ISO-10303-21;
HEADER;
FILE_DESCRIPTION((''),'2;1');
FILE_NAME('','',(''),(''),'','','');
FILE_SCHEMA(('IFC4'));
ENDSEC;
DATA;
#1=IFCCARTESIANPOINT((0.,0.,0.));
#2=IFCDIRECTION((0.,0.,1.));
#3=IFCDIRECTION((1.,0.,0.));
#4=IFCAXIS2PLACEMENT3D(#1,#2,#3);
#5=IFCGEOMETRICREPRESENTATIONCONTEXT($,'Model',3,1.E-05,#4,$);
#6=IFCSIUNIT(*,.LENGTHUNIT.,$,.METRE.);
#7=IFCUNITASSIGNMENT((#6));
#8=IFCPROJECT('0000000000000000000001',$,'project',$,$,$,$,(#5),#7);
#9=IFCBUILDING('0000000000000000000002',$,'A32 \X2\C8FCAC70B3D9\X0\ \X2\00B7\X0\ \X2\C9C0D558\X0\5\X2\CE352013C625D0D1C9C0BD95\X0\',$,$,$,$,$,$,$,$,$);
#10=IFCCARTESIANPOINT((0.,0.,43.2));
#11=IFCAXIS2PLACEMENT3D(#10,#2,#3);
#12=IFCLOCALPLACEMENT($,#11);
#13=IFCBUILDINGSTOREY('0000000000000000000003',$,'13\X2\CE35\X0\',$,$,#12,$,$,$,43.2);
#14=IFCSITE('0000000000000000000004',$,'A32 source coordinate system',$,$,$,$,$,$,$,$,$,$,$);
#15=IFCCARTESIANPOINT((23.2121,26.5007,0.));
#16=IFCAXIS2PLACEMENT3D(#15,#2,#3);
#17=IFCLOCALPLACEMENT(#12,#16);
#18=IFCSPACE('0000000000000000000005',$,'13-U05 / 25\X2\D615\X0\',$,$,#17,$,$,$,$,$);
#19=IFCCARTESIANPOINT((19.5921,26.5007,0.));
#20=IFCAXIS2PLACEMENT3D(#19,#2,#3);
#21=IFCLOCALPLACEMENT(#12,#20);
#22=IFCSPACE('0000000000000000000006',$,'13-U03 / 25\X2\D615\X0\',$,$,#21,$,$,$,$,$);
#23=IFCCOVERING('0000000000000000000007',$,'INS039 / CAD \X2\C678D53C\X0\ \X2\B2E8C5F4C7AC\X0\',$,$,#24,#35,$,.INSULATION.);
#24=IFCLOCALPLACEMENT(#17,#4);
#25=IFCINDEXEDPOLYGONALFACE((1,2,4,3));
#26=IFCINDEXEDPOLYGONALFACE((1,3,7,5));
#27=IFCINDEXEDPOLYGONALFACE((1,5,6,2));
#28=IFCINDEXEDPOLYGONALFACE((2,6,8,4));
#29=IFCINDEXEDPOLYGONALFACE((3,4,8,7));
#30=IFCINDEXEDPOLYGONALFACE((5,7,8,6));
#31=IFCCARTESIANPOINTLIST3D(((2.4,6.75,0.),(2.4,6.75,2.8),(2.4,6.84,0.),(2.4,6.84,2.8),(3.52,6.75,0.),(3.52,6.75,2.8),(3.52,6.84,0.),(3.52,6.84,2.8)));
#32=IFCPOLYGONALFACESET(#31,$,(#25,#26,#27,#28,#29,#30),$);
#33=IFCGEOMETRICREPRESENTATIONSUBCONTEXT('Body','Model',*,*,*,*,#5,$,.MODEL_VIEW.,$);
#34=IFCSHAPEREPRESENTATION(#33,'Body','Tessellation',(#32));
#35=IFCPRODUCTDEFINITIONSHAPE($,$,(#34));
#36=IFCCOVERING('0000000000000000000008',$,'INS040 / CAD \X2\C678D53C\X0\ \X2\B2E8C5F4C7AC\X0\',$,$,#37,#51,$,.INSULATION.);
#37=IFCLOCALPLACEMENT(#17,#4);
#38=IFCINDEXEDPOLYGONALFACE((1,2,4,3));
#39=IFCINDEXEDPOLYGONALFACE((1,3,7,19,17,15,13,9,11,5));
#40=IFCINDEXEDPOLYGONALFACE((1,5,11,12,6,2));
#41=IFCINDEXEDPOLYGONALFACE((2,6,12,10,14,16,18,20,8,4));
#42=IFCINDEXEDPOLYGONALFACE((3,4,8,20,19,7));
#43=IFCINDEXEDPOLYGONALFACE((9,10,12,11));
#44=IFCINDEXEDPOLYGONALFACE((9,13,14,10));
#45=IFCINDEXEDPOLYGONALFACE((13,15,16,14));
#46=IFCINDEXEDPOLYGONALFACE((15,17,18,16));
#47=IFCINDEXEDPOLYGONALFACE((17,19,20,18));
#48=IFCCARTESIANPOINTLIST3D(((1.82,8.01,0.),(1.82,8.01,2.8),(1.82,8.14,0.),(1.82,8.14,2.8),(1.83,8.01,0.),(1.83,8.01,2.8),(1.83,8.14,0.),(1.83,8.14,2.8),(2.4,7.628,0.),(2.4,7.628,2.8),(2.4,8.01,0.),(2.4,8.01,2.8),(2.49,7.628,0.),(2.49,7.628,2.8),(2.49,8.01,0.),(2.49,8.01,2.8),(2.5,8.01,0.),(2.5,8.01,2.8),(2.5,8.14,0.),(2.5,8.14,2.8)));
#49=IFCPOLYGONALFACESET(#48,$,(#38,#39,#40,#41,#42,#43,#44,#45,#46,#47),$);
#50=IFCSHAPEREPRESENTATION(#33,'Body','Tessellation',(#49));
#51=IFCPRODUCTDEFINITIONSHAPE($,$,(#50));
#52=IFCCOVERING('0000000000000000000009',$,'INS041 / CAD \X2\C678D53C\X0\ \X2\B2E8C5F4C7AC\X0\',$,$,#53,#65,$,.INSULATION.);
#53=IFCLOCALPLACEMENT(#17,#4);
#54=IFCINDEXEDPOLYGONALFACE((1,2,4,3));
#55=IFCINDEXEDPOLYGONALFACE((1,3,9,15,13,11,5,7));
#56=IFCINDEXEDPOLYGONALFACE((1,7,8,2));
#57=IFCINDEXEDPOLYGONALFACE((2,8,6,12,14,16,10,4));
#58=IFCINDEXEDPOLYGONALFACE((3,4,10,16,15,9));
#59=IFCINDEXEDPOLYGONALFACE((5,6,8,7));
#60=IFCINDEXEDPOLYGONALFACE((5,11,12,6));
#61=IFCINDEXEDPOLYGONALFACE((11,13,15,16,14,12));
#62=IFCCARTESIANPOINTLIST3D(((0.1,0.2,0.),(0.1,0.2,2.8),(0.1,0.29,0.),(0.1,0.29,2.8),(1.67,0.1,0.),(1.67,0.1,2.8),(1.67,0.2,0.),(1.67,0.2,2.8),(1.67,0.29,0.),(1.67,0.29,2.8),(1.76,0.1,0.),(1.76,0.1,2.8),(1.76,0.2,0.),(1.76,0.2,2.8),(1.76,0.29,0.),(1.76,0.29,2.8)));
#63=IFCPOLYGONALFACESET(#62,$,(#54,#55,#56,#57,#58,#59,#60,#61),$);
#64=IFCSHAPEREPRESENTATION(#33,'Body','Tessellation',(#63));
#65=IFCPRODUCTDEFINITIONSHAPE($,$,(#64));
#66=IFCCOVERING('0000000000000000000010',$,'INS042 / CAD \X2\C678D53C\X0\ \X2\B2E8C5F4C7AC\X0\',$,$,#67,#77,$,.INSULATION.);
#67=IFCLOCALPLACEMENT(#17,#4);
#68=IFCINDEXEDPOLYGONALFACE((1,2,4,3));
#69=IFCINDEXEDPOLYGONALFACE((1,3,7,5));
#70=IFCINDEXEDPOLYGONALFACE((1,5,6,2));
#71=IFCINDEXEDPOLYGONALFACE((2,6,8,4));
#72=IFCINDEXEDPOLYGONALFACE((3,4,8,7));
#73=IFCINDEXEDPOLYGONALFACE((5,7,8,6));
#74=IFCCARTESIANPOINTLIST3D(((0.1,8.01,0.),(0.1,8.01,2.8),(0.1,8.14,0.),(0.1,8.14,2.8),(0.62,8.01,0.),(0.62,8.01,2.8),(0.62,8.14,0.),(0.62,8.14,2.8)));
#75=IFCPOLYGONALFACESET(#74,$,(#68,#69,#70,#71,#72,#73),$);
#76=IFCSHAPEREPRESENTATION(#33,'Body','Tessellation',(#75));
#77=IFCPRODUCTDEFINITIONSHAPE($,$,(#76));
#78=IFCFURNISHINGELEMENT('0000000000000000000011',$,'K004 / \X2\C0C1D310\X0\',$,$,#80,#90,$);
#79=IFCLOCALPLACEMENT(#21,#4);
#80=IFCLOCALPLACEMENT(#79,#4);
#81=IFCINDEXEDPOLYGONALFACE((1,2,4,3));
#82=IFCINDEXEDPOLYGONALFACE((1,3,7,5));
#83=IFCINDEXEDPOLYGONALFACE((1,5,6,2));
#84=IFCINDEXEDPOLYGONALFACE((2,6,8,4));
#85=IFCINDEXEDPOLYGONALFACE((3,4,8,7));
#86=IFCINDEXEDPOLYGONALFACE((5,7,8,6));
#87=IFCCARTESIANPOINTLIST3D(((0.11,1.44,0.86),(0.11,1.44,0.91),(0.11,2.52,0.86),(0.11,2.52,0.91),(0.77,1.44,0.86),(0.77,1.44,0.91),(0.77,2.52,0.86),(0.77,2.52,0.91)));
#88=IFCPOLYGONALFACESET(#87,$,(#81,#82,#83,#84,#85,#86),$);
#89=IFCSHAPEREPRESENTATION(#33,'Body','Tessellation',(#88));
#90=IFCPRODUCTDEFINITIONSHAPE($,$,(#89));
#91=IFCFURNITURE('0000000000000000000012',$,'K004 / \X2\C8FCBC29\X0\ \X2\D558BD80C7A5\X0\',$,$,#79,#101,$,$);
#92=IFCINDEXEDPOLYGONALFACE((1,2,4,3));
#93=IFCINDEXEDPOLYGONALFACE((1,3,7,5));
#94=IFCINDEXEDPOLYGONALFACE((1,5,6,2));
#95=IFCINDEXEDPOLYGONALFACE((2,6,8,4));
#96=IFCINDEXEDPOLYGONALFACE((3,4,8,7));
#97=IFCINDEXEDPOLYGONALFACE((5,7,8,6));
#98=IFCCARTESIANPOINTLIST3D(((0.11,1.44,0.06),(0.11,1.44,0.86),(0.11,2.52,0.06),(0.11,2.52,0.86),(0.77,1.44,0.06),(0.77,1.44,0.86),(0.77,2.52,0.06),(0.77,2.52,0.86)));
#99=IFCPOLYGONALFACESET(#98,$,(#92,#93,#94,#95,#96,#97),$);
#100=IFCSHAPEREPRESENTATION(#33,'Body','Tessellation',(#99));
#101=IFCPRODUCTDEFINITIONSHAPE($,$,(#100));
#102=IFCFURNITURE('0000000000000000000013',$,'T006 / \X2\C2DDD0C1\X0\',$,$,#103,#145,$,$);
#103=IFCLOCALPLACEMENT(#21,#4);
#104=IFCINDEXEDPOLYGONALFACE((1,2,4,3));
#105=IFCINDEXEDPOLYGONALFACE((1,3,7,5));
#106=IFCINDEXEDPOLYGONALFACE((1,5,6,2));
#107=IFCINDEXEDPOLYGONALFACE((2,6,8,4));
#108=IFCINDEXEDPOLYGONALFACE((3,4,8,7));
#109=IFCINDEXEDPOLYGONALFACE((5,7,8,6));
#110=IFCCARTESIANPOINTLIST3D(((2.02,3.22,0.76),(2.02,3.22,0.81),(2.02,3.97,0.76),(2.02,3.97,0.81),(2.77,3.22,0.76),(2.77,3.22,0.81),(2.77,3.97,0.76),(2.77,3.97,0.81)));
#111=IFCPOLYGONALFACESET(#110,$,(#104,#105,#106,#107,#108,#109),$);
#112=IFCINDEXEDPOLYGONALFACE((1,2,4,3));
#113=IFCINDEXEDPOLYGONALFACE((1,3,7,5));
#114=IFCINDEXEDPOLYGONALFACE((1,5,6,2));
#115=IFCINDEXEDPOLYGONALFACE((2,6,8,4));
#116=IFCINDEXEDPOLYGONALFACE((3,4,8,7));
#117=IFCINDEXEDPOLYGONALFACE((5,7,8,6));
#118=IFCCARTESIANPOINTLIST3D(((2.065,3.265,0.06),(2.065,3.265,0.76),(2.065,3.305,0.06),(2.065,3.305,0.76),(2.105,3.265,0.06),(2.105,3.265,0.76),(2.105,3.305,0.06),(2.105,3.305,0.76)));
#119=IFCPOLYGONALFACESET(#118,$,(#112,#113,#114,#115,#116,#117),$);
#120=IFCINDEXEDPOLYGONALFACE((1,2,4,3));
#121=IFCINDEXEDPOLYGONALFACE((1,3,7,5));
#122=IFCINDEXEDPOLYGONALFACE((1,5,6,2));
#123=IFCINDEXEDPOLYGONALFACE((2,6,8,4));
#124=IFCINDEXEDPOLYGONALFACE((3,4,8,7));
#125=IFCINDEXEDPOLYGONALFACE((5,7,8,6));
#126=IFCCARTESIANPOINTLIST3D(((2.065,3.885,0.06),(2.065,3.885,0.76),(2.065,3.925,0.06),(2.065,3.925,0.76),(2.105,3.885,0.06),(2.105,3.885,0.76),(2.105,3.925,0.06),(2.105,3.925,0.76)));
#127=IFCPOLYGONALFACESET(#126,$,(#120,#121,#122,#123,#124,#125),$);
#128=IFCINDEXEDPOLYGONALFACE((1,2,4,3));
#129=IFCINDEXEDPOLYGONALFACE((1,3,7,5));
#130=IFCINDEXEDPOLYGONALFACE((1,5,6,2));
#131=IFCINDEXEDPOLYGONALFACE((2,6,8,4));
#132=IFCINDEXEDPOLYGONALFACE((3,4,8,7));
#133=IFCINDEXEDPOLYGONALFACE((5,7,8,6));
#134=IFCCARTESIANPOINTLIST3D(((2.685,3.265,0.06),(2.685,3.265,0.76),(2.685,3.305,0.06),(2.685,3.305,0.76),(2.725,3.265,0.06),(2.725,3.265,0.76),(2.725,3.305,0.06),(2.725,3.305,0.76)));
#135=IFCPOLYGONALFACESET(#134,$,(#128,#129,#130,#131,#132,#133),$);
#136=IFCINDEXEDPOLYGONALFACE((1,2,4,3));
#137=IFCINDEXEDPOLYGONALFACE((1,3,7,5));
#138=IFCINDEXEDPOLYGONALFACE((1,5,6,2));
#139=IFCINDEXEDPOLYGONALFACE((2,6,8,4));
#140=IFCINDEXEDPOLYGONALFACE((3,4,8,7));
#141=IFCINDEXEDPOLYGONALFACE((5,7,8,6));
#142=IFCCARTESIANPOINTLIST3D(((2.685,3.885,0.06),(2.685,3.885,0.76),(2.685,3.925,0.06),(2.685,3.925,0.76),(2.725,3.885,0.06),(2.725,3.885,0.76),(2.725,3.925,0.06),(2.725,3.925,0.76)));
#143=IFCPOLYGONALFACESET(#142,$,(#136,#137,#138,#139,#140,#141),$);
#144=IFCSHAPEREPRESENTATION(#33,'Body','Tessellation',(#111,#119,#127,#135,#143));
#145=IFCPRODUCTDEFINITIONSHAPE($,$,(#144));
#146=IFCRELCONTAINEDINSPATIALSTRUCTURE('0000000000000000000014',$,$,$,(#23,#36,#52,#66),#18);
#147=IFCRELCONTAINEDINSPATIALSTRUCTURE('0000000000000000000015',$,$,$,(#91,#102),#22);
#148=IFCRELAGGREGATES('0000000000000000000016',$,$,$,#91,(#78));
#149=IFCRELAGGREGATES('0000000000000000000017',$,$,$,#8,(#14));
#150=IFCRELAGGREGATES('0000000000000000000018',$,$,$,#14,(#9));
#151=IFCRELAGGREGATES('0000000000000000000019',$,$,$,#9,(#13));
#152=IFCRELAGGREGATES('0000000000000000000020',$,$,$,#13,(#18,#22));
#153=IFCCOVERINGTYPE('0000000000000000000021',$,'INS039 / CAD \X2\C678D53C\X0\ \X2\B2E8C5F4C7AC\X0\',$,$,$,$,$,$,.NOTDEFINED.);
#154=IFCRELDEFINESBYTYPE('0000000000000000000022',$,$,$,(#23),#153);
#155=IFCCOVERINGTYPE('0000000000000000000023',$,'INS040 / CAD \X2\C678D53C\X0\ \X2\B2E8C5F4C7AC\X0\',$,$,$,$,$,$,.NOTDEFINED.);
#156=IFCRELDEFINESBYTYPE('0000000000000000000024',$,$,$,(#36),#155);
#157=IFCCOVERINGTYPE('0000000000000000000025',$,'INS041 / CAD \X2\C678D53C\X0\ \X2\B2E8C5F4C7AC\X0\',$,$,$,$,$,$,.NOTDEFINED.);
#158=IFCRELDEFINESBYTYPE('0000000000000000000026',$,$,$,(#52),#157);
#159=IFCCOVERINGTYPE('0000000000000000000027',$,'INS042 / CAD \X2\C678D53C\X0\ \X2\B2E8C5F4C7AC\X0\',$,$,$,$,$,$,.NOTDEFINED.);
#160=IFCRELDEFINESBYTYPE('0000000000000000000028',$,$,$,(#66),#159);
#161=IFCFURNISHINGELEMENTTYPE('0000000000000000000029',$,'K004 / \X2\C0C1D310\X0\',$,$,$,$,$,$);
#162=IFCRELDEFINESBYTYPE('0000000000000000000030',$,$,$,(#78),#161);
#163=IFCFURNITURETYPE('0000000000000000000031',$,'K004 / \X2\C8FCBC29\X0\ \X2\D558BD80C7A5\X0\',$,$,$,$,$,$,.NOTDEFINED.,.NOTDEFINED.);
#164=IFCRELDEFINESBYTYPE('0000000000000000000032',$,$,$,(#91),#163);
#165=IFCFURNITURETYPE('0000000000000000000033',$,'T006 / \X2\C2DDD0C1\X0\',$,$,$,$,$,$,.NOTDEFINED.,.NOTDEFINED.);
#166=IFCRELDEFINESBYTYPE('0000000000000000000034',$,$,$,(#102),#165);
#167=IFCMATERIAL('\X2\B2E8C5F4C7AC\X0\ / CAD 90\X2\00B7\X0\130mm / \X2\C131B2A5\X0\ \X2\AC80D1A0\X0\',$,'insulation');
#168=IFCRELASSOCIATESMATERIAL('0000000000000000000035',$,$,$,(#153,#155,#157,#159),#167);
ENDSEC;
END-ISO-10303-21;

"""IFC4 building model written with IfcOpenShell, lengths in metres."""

from ifc_helpers import new_model, si_unit, frame, origin, origin_with_axes, place, context, subcontext, project, spatial, polyline, outline, extrude, source, transform, mapped, material, type_object, type_shapes, element, aggregate, save


model = new_model("IFC4")

# Units and contexts
model_context = context("Model", 3, precision=1e-05, world=origin_with_axes())
body_context = subcontext(model_context, "Body", "Model", "MODEL_VIEW")
ifc_project = project(units=[si_unit("LENGTHUNIT", "METRE")], contexts=[model_context])

# Site, building, storey, space
storey_placement = place(None, frame((0.0, 0.0, 43.2), z_axis=(0.0, 0.0, 1.0), x_axis=(1.0, 0.0, 0.0)))
space_1_placement = place(storey_placement, frame((23.2121, 26.5007, 0.0), z_axis=(0.0, 0.0, 1.0), x_axis=(1.0, 0.0, 0.0)))
site = spatial("IfcSite", under=ifc_project, Name="A32 source coordinate system")
building = spatial("IfcBuilding", under=site, Name="A32 주거동 · 지하5층–옥탑지붕")
storey = spatial("IfcBuildingStorey", under=building, at=storey_placement, Name="13층", Elevation=43.2)
space_1 = spatial("IfcSpace", under=storey, at=space_1_placement, Name="13-U05 / 25형")

# Shared definitions
space_2_placement = place(storey_placement, frame((19.5921, 26.5007, 0.0), z_axis=(0.0, 0.0, 1.0), x_axis=(1.0, 0.0, 0.0)))
space_2 = spatial("IfcSpace", under=storey, at=space_2_placement, Name="13-U03 / 25형")

# Coverings
ifc_material = material(Name="단열재 / CAD 90·130mm / 성능 검토", Category="insulation")
covering_type_1 = type_object("IfcCoveringType", Name="INS039 / CAD 외피 단열재", PredefinedType="NOTDEFINED", material=ifc_material)
shared_shape_1 = source(origin(), body_context, "Body", "SweptSolid", [
    extrude(outline(polyline([(2.4, 6.75), (2.4, 6.84), (3.52, 6.84), (3.52, 6.75), (2.4, 6.75)])), origin(), (0.0, 0.0, 1.0), 2.8),
])
type_shapes(covering_type_1, [shared_shape_1])
covering_1_placement = place(space_1_placement, origin_with_axes())
element("IfcCovering", 1, at=covering_1_placement, inside=space_1, type_object=covering_type_1, Name="INS039 / CAD 외피 단열재", PredefinedType="INSULATION", context=body_context, shape_type="MappedRepresentation", body=[
    mapped(shared_shape_1, transform((0.0, 0.0, 0.0), scale=1.0)),
])
covering_type_2 = type_object("IfcCoveringType", Name="INS040 / CAD 외피 단열재", PredefinedType="NOTDEFINED", material=ifc_material)
shared_shape_2 = source(origin(), body_context, "Body", "SweptSolid", [
    extrude(outline(polyline([(2.4, 7.628), (2.4, 8.01), (1.83, 8.01), (1.82, 8.01), (1.82, 8.14), (1.83, 8.14), (2.5, 8.14), (2.5, 8.01), (2.49, 8.01), (2.49, 7.628), (2.4, 7.628)])), origin(), (0.0, 0.0, 1.0), 2.8),
])
type_shapes(covering_type_2, [shared_shape_2])
covering_2_placement = place(space_1_placement, origin_with_axes())
element("IfcCovering", 2, at=covering_2_placement, inside=space_1, type_object=covering_type_2, Name="INS040 / CAD 외피 단열재", PredefinedType="INSULATION", context=body_context, shape_type="MappedRepresentation", body=[
    mapped(shared_shape_2, transform((0.0, 0.0, 0.0), scale=1.0)),
])
covering_type_3 = type_object("IfcCoveringType", Name="INS041 / CAD 외피 단열재", PredefinedType="NOTDEFINED", material=ifc_material)
shared_shape_3 = source(origin(), body_context, "Body", "SweptSolid", [
    extrude(outline(polyline([(1.67, 0.2), (0.1, 0.2), (0.1, 0.29), (1.67, 0.29), (1.76, 0.29), (1.76, 0.2), (1.76, 0.1), (1.67, 0.1), (1.67, 0.2)])), origin(), (0.0, 0.0, 1.0), 2.8),
])
type_shapes(covering_type_3, [shared_shape_3])
covering_3_placement = place(space_1_placement, origin_with_axes())
element("IfcCovering", 3, at=covering_3_placement, inside=space_1, type_object=covering_type_3, Name="INS041 / CAD 외피 단열재", PredefinedType="INSULATION", context=body_context, shape_type="MappedRepresentation", body=[
    mapped(shared_shape_3, transform((0.0, 0.0, 0.0), scale=1.0)),
])
covering_type_4 = type_object("IfcCoveringType", Name="INS042 / CAD 외피 단열재", PredefinedType="NOTDEFINED", material=ifc_material)
shared_shape_4 = source(origin(), body_context, "Body", "SweptSolid", [
    extrude(outline(polyline([(0.62, 8.14), (0.62, 8.01), (0.1, 8.01), (0.1, 8.14), (0.62, 8.14)])), origin(), (0.0, 0.0, 1.0), 2.8),
])
type_shapes(covering_type_4, [shared_shape_4])
covering_4_placement = place(space_1_placement, origin_with_axes())
element("IfcCovering", 4, at=covering_4_placement, inside=space_1, type_object=covering_type_4, Name="INS042 / CAD 외피 단열재", PredefinedType="INSULATION", context=body_context, shape_type="MappedRepresentation", body=[
    mapped(shared_shape_4, transform((0.0, 0.0, 0.0), scale=1.0)),
])

# Furnishing element
furnishing_element_type_1 = type_object("IfcFurnishingElementType", Name="K004 / 상판")
shared_shape_5 = source(origin(), body_context, "Body", "SweptSolid", [
    extrude(outline(polyline([(0.77, 2.52), (0.77, 1.44), (0.11, 1.44), (0.11, 2.52), (0.77, 2.52)])), frame((0.0, 0.0, 0.86)), (0.0, 0.0, 1.0), 0.05),
])
type_shapes(furnishing_element_type_1, [shared_shape_5])
furniture_1_placement = place(space_2_placement, origin_with_axes())
furnishing_1_placement = place(furniture_1_placement, origin_with_axes())
furnishing_1 = element("IfcFurnishingElement", 5, at=furnishing_1_placement, type_object=furnishing_element_type_1, Name="K004 / 상판", context=body_context, shape_type="MappedRepresentation", body=[
    mapped(shared_shape_5, transform((0.0, 0.0, 0.0), scale=1.0)),
])

# Furniture
furniture_type_1 = type_object("IfcFurnitureType", Name="K004 / 주방 하부장", AssemblyPlace="NOTDEFINED", PredefinedType="NOTDEFINED")
shared_shape_6 = source(origin(), body_context, "Body", "SweptSolid", [
    extrude(outline(polyline([(0.11, 2.52), (0.77, 2.52), (0.77, 1.44), (0.11, 1.44), (0.11, 2.52)])), frame((0.0, 0.0, 0.06)), (0.0, 0.0, 1.0), 0.8),
])
type_shapes(furniture_type_1, [shared_shape_6])
furniture_1 = element("IfcFurniture", 6, at=furniture_1_placement, inside=space_2, type_object=furniture_type_1, Name="K004 / 주방 하부장", context=body_context, shape_type="MappedRepresentation", body=[
    mapped(shared_shape_6, transform((0.0, 0.0, 0.0), scale=1.0)),
])
aggregate(furniture_1, [furnishing_1])
furniture_type_2 = type_object("IfcFurnitureType", Name="T006 / 식탁", AssemblyPlace="NOTDEFINED", PredefinedType="NOTDEFINED")
shared_shape_7 = source(origin(), body_context, "Body", "SweptSolid", [
    extrude(outline(polyline([(2.77, 3.22), (2.02, 3.22), (2.02, 3.97), (2.77, 3.97), (2.77, 3.22)])), frame((0.0, 0.0, 0.76)), (0.0, 0.0, 1.0), 0.05),
    extrude(outline(polyline([(2.065, 3.265), (2.065, 3.305), (2.105, 3.305), (2.105, 3.265), (2.065, 3.265)])), frame((0.0, 0.0, 0.06)), (0.0, 0.0, 1.0), 0.7),
    extrude(outline(polyline([(2.065, 3.885), (2.065, 3.925), (2.105, 3.925), (2.105, 3.885), (2.065, 3.885)])), frame((0.0, 0.0, 0.06)), (0.0, 0.0, 1.0), 0.7),
    extrude(outline(polyline([(2.685, 3.265), (2.685, 3.305), (2.725, 3.305), (2.725, 3.265), (2.685, 3.265)])), frame((0.0, 0.0, 0.06)), (0.0, 0.0, 1.0), 0.7),
    extrude(outline(polyline([(2.685, 3.885), (2.685, 3.925), (2.725, 3.925), (2.725, 3.885), (2.685, 3.885)])), frame((0.0, 0.0, 0.06)), (0.0, 0.0, 1.0), 0.7),
])
type_shapes(furniture_type_2, [shared_shape_7])
furniture_2_placement = place(space_2_placement, origin_with_axes())
element("IfcFurniture", 7, at=furniture_2_placement, inside=space_2, type_object=furniture_type_2, Name="T006 / 식탁", context=body_context, shape_type="MappedRepresentation", body=[
    mapped(shared_shape_7, transform((0.0, 0.0, 0.0), scale=1.0)),
])

save(model, "model.ifc")
